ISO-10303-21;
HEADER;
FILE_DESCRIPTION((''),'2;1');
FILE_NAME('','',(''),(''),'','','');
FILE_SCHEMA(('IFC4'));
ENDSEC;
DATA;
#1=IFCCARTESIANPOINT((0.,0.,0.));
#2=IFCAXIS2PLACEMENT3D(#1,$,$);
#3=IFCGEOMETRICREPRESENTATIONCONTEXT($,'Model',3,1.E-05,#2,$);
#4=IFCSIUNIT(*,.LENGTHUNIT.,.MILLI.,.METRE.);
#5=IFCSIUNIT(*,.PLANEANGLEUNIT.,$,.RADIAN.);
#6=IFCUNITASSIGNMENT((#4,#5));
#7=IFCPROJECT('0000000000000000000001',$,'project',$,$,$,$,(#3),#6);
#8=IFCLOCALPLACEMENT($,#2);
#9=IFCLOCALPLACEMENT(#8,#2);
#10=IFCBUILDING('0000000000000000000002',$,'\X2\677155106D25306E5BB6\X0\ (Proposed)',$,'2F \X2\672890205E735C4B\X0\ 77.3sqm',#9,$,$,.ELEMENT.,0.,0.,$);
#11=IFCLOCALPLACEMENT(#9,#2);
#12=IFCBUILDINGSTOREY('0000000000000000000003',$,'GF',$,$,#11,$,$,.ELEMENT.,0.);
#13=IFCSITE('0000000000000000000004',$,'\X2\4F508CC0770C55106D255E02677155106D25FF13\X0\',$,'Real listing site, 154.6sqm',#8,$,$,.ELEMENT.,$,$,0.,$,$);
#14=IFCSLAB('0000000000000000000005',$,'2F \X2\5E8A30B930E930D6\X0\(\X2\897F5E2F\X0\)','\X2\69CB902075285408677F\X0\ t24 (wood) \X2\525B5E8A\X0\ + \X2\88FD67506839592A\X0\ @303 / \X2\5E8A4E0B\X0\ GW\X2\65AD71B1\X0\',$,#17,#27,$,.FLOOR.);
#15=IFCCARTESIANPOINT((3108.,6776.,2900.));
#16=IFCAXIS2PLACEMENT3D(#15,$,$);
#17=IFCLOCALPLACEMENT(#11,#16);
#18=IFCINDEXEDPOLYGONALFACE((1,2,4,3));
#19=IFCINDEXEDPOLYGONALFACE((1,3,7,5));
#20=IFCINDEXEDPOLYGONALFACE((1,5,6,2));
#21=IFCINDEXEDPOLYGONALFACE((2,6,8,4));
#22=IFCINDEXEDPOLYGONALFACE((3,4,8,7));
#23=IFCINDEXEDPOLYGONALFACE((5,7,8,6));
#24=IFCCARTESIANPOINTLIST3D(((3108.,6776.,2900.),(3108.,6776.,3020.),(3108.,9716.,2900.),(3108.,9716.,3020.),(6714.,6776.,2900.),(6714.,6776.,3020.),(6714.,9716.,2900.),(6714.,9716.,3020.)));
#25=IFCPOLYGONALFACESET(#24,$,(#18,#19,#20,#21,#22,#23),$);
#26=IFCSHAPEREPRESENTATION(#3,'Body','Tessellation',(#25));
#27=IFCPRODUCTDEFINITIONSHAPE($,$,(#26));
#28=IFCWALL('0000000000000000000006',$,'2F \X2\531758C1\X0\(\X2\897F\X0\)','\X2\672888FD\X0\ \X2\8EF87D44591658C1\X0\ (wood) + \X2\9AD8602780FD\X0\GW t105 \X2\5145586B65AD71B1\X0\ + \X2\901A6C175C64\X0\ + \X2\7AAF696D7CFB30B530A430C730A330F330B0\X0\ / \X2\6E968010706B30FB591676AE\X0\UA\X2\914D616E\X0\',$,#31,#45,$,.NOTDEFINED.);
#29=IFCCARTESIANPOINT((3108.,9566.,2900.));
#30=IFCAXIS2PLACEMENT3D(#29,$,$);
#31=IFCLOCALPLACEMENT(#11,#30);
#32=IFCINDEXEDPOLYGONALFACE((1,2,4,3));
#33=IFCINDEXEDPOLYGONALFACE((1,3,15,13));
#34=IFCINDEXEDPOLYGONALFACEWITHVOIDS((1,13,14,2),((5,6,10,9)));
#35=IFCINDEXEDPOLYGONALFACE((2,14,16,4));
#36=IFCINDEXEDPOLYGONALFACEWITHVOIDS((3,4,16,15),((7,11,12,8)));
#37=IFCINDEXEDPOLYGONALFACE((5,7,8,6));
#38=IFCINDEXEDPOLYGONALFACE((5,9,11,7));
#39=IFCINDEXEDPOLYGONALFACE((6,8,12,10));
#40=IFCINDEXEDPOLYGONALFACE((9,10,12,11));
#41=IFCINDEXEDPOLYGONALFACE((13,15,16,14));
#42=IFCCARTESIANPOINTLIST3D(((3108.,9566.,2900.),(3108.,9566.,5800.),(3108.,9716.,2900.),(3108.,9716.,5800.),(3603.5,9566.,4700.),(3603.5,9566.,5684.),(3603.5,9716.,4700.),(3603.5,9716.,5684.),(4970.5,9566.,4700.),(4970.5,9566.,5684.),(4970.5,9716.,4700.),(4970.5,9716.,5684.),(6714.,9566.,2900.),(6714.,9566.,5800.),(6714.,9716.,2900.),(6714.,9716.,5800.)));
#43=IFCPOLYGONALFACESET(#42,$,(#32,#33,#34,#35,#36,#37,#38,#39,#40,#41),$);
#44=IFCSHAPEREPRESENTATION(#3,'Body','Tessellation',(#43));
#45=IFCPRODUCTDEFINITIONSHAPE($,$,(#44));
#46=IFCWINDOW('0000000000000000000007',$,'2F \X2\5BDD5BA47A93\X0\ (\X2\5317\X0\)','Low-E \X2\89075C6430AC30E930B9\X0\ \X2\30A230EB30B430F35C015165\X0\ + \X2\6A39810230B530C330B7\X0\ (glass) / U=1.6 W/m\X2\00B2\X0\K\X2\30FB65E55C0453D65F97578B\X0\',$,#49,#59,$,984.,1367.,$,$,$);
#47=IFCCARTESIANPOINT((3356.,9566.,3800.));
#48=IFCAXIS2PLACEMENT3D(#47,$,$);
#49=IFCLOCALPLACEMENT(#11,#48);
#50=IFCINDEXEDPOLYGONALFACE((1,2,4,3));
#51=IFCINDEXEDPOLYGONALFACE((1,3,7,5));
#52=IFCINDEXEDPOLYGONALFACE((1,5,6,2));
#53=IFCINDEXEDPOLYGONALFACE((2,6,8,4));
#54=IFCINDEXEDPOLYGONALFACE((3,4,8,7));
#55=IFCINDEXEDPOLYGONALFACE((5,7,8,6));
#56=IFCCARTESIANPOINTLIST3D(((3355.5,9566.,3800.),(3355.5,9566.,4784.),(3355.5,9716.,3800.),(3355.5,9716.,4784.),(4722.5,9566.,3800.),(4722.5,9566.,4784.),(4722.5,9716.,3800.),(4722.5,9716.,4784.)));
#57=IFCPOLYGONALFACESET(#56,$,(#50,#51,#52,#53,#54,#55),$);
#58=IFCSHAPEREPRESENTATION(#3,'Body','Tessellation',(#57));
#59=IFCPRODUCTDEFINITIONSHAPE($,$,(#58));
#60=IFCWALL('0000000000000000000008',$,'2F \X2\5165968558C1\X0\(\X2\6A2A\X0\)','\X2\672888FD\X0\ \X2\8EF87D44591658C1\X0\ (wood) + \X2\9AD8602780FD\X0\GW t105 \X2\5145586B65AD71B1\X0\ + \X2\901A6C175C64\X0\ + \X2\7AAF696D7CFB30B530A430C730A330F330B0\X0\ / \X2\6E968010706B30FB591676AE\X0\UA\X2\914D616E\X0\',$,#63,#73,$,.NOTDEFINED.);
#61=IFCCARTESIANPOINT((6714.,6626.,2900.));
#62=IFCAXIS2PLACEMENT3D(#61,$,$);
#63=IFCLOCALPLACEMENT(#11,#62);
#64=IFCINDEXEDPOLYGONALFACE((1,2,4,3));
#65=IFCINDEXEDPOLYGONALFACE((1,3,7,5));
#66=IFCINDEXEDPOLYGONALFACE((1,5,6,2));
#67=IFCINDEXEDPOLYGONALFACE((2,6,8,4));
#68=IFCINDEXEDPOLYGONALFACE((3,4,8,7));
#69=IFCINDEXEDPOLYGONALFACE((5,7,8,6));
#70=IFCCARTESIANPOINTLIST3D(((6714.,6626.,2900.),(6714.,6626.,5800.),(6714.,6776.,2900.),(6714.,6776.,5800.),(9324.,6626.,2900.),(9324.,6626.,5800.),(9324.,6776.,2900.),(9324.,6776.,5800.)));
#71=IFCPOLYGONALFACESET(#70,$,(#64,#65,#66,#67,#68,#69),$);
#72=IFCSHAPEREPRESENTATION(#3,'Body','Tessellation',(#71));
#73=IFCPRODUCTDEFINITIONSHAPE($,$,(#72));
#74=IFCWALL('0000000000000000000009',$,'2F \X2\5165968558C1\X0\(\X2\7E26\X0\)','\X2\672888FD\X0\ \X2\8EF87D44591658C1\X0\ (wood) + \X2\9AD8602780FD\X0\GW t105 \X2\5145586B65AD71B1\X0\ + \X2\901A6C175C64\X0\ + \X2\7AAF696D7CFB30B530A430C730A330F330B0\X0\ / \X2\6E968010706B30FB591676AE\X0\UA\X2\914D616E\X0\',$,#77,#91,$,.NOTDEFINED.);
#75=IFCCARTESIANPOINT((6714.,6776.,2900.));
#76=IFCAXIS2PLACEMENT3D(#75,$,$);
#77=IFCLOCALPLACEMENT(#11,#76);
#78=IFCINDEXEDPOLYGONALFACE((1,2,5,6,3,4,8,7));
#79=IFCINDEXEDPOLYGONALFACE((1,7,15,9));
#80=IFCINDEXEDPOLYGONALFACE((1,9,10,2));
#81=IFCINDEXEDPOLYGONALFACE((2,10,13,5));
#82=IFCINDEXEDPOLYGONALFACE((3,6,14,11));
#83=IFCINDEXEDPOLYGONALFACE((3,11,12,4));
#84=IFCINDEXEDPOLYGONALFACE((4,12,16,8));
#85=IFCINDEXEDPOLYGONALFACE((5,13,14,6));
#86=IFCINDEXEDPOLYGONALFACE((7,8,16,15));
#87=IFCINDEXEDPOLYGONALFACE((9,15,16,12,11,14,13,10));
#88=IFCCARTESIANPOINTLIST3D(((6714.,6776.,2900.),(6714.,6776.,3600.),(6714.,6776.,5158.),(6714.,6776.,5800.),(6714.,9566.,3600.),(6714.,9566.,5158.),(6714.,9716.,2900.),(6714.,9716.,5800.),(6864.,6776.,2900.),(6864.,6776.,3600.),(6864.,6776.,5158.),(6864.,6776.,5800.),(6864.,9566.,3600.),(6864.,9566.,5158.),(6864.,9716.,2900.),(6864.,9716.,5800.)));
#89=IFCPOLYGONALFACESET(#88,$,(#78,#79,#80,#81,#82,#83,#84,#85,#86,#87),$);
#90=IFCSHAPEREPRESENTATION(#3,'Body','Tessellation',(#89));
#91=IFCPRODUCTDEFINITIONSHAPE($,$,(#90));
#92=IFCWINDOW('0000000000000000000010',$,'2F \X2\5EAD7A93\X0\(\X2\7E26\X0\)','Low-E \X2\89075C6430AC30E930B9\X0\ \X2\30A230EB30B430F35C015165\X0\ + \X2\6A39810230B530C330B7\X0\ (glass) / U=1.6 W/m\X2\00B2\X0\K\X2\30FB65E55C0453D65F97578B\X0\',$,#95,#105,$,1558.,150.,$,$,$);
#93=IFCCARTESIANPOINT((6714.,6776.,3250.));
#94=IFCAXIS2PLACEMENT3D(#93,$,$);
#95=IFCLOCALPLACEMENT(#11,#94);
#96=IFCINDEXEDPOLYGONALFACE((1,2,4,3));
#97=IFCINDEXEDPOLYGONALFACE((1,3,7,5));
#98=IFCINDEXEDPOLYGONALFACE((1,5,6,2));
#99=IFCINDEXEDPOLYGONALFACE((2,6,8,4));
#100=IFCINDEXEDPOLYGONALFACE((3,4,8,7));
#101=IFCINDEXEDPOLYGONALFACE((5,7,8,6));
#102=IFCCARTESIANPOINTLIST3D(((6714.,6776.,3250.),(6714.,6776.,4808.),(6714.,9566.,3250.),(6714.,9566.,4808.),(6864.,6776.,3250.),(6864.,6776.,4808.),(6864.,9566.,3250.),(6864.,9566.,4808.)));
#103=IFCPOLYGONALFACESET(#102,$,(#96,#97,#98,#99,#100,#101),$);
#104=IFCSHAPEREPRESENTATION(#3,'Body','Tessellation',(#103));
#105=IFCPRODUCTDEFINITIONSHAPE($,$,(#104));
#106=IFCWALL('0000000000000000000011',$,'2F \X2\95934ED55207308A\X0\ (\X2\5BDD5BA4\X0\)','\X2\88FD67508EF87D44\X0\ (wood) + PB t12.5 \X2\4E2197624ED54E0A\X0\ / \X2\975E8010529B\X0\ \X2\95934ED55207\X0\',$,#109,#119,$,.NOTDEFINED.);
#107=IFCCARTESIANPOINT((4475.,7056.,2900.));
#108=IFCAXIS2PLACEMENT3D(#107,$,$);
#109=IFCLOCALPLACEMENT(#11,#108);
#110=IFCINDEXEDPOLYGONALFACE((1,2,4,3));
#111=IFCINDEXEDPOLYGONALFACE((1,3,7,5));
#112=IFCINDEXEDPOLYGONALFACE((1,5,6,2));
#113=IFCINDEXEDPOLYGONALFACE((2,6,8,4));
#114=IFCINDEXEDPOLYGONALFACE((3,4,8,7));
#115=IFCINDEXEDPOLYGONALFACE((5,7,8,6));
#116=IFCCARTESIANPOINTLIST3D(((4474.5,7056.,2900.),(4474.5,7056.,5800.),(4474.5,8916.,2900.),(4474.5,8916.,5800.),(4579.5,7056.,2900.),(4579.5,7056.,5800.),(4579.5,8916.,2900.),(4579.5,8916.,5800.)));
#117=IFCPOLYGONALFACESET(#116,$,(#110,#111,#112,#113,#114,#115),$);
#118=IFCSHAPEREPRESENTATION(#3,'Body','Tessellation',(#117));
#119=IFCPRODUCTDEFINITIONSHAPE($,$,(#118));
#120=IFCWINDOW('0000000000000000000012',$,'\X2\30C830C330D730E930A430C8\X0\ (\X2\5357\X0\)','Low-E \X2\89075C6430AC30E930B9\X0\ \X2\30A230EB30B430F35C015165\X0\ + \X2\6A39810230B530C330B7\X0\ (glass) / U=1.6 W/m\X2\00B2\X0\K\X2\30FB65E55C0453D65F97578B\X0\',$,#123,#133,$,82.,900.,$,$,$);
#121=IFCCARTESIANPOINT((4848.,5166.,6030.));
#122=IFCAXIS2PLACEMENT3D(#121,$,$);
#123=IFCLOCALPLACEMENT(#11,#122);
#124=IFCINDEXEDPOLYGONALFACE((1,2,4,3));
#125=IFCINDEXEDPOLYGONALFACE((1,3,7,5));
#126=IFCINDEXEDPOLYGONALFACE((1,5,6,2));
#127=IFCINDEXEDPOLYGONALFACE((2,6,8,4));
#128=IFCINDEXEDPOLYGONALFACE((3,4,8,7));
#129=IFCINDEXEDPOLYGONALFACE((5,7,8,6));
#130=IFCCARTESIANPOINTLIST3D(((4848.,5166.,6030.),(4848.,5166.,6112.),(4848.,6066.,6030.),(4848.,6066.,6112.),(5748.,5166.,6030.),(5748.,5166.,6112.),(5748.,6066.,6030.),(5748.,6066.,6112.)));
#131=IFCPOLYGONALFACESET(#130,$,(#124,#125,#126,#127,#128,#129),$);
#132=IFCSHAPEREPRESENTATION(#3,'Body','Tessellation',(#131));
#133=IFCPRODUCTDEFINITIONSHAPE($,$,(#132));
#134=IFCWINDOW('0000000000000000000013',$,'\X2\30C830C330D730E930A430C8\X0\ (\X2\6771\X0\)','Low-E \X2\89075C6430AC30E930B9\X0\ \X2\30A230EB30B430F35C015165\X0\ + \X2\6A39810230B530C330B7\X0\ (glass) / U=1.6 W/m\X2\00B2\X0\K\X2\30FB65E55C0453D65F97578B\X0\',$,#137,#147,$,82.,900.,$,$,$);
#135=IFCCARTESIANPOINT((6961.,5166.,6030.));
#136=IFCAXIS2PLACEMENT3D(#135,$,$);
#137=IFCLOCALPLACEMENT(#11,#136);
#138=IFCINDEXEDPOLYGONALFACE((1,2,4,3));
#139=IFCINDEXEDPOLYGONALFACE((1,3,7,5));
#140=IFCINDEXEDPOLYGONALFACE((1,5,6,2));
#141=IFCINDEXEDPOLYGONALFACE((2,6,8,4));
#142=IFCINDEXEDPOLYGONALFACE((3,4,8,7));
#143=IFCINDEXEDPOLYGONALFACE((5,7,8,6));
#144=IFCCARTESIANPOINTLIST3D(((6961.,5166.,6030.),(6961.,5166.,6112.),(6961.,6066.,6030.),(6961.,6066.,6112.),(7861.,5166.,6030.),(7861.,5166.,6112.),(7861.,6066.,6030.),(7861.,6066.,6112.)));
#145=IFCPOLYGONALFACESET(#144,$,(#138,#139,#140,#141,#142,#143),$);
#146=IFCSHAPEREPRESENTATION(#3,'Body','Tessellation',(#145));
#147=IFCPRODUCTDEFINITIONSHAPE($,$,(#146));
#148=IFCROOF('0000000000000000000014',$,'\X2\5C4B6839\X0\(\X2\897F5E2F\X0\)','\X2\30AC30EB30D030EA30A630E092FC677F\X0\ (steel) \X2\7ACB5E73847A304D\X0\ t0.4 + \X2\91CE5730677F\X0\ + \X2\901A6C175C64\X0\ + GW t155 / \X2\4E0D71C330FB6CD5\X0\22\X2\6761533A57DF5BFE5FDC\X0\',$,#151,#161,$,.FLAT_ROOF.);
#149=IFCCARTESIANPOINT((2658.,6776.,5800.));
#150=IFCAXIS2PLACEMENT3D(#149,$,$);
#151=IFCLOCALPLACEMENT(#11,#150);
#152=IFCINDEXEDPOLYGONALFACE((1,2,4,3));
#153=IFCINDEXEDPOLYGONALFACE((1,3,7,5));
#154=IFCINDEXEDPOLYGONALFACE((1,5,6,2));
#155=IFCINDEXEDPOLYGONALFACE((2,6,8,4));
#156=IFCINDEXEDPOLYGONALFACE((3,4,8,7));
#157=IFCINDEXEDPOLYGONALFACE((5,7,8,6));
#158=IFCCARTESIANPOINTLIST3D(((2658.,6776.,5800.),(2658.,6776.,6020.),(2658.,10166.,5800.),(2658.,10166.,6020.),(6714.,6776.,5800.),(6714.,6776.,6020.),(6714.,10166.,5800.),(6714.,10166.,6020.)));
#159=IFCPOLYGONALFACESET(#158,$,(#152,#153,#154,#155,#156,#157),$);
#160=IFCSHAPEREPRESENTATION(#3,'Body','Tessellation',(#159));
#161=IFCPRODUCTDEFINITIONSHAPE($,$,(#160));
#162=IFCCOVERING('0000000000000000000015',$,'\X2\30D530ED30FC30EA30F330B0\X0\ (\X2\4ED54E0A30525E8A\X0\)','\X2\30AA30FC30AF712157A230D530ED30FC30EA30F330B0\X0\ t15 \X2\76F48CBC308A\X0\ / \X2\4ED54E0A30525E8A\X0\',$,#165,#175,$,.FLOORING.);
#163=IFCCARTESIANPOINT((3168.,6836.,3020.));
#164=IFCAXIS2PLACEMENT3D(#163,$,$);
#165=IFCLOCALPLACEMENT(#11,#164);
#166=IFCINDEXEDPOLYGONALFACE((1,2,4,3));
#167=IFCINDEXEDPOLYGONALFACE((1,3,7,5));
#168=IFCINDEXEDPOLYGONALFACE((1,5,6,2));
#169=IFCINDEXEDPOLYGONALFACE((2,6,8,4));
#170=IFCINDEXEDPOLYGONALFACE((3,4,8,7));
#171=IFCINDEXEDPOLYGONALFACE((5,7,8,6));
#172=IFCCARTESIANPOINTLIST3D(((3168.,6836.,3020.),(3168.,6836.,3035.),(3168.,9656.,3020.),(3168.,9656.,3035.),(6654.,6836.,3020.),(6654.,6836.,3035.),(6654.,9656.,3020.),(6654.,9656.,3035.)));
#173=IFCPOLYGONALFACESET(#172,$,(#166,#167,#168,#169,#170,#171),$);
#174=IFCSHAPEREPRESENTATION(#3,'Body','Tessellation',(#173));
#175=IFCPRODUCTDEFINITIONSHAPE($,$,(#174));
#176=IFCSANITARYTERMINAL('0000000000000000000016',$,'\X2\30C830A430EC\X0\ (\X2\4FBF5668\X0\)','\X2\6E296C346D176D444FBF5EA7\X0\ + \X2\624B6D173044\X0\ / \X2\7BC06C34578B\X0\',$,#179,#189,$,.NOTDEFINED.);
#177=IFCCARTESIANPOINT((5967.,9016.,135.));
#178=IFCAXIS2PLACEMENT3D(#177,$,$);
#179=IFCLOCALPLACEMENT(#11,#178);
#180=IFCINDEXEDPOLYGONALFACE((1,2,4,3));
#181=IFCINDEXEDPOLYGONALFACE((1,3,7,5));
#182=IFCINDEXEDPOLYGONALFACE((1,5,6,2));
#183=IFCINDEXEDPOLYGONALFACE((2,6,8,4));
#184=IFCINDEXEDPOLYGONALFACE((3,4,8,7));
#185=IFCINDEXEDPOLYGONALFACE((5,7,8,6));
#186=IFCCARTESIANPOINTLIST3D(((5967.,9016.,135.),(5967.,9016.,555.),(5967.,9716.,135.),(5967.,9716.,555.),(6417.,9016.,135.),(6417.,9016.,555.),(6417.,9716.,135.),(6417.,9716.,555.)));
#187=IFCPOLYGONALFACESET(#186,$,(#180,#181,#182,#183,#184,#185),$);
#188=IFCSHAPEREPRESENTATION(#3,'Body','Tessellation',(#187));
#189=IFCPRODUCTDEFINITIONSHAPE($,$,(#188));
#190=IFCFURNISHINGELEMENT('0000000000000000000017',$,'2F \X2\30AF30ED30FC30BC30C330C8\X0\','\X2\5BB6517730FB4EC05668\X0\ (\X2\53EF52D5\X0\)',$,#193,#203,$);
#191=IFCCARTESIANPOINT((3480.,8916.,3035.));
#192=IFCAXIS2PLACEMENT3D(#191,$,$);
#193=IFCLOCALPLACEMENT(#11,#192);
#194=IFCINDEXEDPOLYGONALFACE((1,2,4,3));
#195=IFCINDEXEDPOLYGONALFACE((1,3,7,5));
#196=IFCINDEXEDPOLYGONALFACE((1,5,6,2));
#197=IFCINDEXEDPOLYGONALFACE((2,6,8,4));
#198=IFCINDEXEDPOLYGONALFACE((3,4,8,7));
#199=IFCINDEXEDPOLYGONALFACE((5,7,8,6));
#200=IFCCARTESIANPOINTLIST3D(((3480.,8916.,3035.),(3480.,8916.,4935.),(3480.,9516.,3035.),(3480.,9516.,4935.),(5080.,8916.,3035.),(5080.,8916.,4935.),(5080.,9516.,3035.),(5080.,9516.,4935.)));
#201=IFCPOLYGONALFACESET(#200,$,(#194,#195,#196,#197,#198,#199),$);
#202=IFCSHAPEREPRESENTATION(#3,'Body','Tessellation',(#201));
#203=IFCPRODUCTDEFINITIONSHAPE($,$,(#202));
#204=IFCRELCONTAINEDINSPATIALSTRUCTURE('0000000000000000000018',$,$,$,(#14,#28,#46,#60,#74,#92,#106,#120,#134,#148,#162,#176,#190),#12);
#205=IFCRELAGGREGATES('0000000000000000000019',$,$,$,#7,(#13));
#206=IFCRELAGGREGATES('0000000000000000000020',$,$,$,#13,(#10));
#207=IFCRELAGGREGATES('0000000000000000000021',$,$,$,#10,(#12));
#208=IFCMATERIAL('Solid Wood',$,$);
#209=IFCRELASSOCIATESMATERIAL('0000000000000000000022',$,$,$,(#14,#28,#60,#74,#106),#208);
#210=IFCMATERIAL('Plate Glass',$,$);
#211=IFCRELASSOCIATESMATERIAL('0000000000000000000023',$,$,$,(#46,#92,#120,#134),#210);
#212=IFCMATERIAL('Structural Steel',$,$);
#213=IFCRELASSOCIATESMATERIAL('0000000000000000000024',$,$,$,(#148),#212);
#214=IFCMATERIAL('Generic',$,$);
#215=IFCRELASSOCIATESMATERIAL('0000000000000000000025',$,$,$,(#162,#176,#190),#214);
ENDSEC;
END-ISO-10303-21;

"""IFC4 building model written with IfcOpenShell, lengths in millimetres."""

from ifc_helpers import new_model, si_unit, frame, frame_2d, origin, place, context, project, spatial, rectangle, extrude, material, element, fill, save


model = new_model("IFC4")

# Units and contexts
model_context = context("Model", 3, precision=1e-05, world=origin())
ifc_project = project(units=[si_unit("LENGTHUNIT", "METRE", prefix="MILLI"), si_unit("PLANEANGLEUNIT", "RADIAN")], contexts=[model_context])

# Site, building, storey
site_placement = place(None, origin())
site = spatial("IfcSite", under=ifc_project, at=site_placement, Name="佐賀県唐津市東唐津３", ObjectType="Real listing site, 154.6sqm", CompositionType="ELEMENT", RefElevation=0.0)
building_placement = place(site_placement, origin())
building = spatial("IfcBuilding", under=site, at=building_placement, Name="東唐津の家 (Proposed)", ObjectType="2F 木造平屋 77.3sqm", CompositionType="ELEMENT", ElevationOfRefHeight=0.0, ElevationOfTerrain=0.0)
storey_placement = place(building_placement, origin())
storey = spatial("IfcBuildingStorey", under=building, at=storey_placement, Name="GF", CompositionType="ELEMENT", Elevation=0.0)

# Slab
ifc_material_1 = material(Name="Solid Wood")
slab_placement = place(storey_placement, frame((3108.0, 6776.0, 2900.0)))
element("IfcSlab", 1, at=slab_placement, inside=storey, material=ifc_material_1, Name="2F 床スラブ(西帯)", Description="構造用合板 t24 (wood) 剛床 + 製材根太 @303 / 床下 GW断熱", PredefinedType="FLOOR", context=model_context, shape_type="SweptSolid", body=[
    extrude(rectangle(XDim=3606.0, YDim=2940.0, at=frame_2d((1803.0, 1470.0))), frame((3108.0, 6776.0, 2900.0)), (0.0, 0.0, 1.0), 120.0),
])

# Wall, opening, window
wall_1_placement = place(storey_placement, frame((3108.0, 9566.0, 2900.0)))
wall_1 = element("IfcWall", 2, at=wall_1_placement, inside=storey, material=ifc_material_1, Name="2F 北壁(西)", Description="木製 軸組外壁 (wood) + 高性能GW t105 充填断熱 + 通気層 + 窯業系サイディング / 準耐火・外皮UA配慮", PredefinedType="NOTDEFINED", context=model_context, shape_type="SweptSolid", body=[
    extrude(rectangle(XDim=3606.0, YDim=150.0, at=frame_2d((1803.0, 75.0))), frame((3108.0, 9566.0, 2900.0)), (0.0, 0.0, 1.0), 2900.0),
])
opening_1_placement = place(storey_placement, frame((3356.0, 9566.0, 3800.0)))
opening_1 = element("IfcOpeningElement", 3, at=opening_1_placement, cuts=wall_1, PredefinedType="NOTDEFINED", context=model_context, shape_type="SweptSolid", body=[
    extrude(rectangle(XDim=1367.0, YDim=150.0, at=frame_2d((683.0, 75.0))), frame((3356.0, 9566.0, 3800.0)), (0.0, 0.0, 1.0), 984.0),
])
ifc_material_2 = material(Name="Plate Glass")
window_1_placement = place(storey_placement, frame((3356.0, 9566.0, 3800.0)))
window_1 = element("IfcWindow", 4, at=window_1_placement, inside=storey, material=ifc_material_2, Name="2F 寝室窓 (北)", Description="Low-E 複層ガラス アルゴン封入 + 樹脂サッシ (glass) / U=1.6 W/m²K・日射取得型", OverallHeight=984.0, OverallWidth=1367.0, context=model_context, shape_type="SweptSolid", body=[
    extrude(rectangle(XDim=1367.0, YDim=150.0, at=frame_2d((683.0, 75.0))), frame((3356.0, 9566.0, 3800.0)), (0.0, 0.0, 1.0), 984.0),
])
fill(opening_1, window_1)

# Wall
wall_2_placement = place(storey_placement, frame((6714.0, 6626.0, 2900.0)))
element("IfcWall", 5, at=wall_2_placement, inside=storey, material=ifc_material_1, Name="2F 入隅壁(横)", Description="木製 軸組外壁 (wood) + 高性能GW t105 充填断熱 + 通気層 + 窯業系サイディング / 準耐火・外皮UA配慮", PredefinedType="NOTDEFINED", context=model_context, shape_type="SweptSolid", body=[
    extrude(rectangle(XDim=2610.0, YDim=150.0, at=frame_2d((1305.0, 75.0))), frame((6714.0, 6626.0, 2900.0)), (0.0, 0.0, 1.0), 2900.0),
])

# Wall, opening, window
wall_3_placement = place(storey_placement, frame((6714.0, 6776.0, 2900.0)))
wall_3 = element("IfcWall", 6, at=wall_3_placement, inside=storey, material=ifc_material_1, Name="2F 入隅壁(縦)", Description="木製 軸組外壁 (wood) + 高性能GW t105 充填断熱 + 通気層 + 窯業系サイディング / 準耐火・外皮UA配慮", PredefinedType="NOTDEFINED", context=model_context, shape_type="SweptSolid", body=[
    extrude(rectangle(XDim=150.0, YDim=2940.0, at=frame_2d((75.0, 1470.0))), frame((6714.0, 6776.0, 2900.0)), (0.0, 0.0, 1.0), 2900.0),
])
opening_2_placement = place(storey_placement, frame((6714.0, 6776.0, 3250.0)))
opening_2 = element("IfcOpeningElement", 7, at=opening_2_placement, cuts=wall_3, PredefinedType="NOTDEFINED", context=model_context, shape_type="SweptSolid", body=[
    extrude(rectangle(XDim=150.0, YDim=2790.0, at=frame_2d((75.0, 1395.0))), frame((6714.0, 6776.0, 3250.0)), (0.0, 0.0, 1.0), 1558.0),
])
window_2_placement = place(storey_placement, frame((6714.0, 6776.0, 3250.0)))
window_2 = element("IfcWindow", 8, at=window_2_placement, inside=storey, material=ifc_material_2, Name="2F 庭窓(縦)", Description="Low-E 複層ガラス アルゴン封入 + 樹脂サッシ (glass) / U=1.6 W/m²K・日射取得型", OverallHeight=1558.0, OverallWidth=150.0, context=model_context, shape_type="SweptSolid", body=[
    extrude(rectangle(XDim=150.0, YDim=2790.0, at=frame_2d((75.0, 1395.0))), frame((6714.0, 6776.0, 3250.0)), (0.0, 0.0, 1.0), 1558.0),
])
fill(opening_2, window_2)

# Wall
wall_4_placement = place(storey_placement, frame((4475.0, 7056.0, 2900.0)))
element("IfcWall", 9, at=wall_4_placement, inside=storey, material=ifc_material_1, Name="2F 間仕切り (寝室)", Description="製材軸組 (wood) + PB t12.5 両面仕上 / 非耐力 間仕切", PredefinedType="NOTDEFINED", context=model_context, shape_type="SweptSolid", body=[
    extrude(rectangle(XDim=105.0, YDim=1860.0, at=frame_2d((52.0, 930.0))), frame((4475.0, 7056.0, 2900.0)), (0.0, 0.0, 1.0), 2900.0),
])

# Windows
window_3_placement = place(storey_placement, frame((4848.0, 5166.0, 6030.0)))
element("IfcWindow", 10, at=window_3_placement, inside=storey, material=ifc_material_2, Name="トップライト (南)", Description="Low-E 複層ガラス アルゴン封入 + 樹脂サッシ (glass) / U=1.6 W/m²K・日射取得型", OverallHeight=82.0, OverallWidth=900.0, context=model_context, shape_type="SweptSolid", body=[
    extrude(rectangle(XDim=900.0, YDim=900.0, at=frame_2d((450.0, 450.0))), frame((4848.0, 5166.0, 6030.0)), (0.0, 0.0, 1.0), 82.0),
])
window_4_placement = place(storey_placement, frame((6961.0, 5166.0, 6030.0)))
element("IfcWindow", 11, at=window_4_placement, inside=storey, material=ifc_material_2, Name="トップライト (東)", Description="Low-E 複層ガラス アルゴン封入 + 樹脂サッシ (glass) / U=1.6 W/m²K・日射取得型", OverallHeight=82.0, OverallWidth=900.0, context=model_context, shape_type="SweptSolid", body=[
    extrude(rectangle(XDim=900.0, YDim=900.0, at=frame_2d((450.0, 450.0))), frame((6961.0, 5166.0, 6030.0)), (0.0, 0.0, 1.0), 82.0),
])

# Roof
ifc_material_3 = material(Name="Structural Steel")
for number, where, name in (
    (12, (2658.0, 6776.0, 5800.0), "屋根(西帯)"),
):
    element("IfcRoof", number, at=place(storey_placement, frame(where)), inside=storey, material=ifc_material_3, Name=name, Description="ガルバリウム鋼板 (steel) 立平葺き t0.4 + 野地板 + 通気層 + GW t155 / 不燃・法22条区域対応", PredefinedType="FLAT_ROOF", context=model_context, shape_type="SweptSolid", body=[
        extrude(rectangle(XDim=4056.0, YDim=3390.0, at=frame_2d((2028.0, 1695.0))), frame((2658.0, 6776.0, 5800.0)), (0.0, 0.0, 1.0), 220.0),
    ])

# Covering
ifc_material_4 = material(Name="Generic")
covering_placement = place(storey_placement, frame((3168.0, 6836.0, 3020.0)))
element("IfcCovering", 13, at=covering_placement, inside=storey, material=ifc_material_4, Name="フローリング (仕上げ床)", Description="オーク無垢フローリング t15 直貼り / 仕上げ床", PredefinedType="FLOORING", context=model_context, shape_type="SweptSolid", body=[
    extrude(rectangle(XDim=3486.0, YDim=2820.0, at=frame_2d((1743.0, 1410.0))), frame((3168.0, 6836.0, 3020.0)), (0.0, 0.0, 1.0), 15.0),
])

# Sanitary terminal
sanitary_terminal_placement = place(storey_placement, frame((5967.0, 9016.0, 135.0)))
element("IfcSanitaryTerminal", 14, at=sanitary_terminal_placement, inside=storey, material=ifc_material_4, Name="トイレ (便器)", Description="温水洗浄便座 + 手洗い / 節水型", PredefinedType="NOTDEFINED", context=model_context, shape_type="SweptSolid", body=[
    extrude(rectangle(XDim=450.0, YDim=700.0, at=frame_2d((225.0, 350.0))), frame((5967.0, 9016.0, 135.0)), (0.0, 0.0, 1.0), 420.0),
])

# Furnishing element
furnishing_1_placement = place(storey_placement, frame((3480.0, 8916.0, 3035.0)))
element("IfcFurnishingElement", 15, at=furnishing_1_placement, inside=storey, material=ifc_material_4, Name="2F クローゼット", Description="家具・什器 (可動)", context=model_context, shape_type="SweptSolid", body=[
    extrude(rectangle(XDim=1600.0, YDim=600.0, at=frame_2d((800.0, 300.0))), frame((3480.0, 8916.0, 3035.0)), (0.0, 0.0, 1.0), 1900.0),
])

save(model, "model.ifc")
